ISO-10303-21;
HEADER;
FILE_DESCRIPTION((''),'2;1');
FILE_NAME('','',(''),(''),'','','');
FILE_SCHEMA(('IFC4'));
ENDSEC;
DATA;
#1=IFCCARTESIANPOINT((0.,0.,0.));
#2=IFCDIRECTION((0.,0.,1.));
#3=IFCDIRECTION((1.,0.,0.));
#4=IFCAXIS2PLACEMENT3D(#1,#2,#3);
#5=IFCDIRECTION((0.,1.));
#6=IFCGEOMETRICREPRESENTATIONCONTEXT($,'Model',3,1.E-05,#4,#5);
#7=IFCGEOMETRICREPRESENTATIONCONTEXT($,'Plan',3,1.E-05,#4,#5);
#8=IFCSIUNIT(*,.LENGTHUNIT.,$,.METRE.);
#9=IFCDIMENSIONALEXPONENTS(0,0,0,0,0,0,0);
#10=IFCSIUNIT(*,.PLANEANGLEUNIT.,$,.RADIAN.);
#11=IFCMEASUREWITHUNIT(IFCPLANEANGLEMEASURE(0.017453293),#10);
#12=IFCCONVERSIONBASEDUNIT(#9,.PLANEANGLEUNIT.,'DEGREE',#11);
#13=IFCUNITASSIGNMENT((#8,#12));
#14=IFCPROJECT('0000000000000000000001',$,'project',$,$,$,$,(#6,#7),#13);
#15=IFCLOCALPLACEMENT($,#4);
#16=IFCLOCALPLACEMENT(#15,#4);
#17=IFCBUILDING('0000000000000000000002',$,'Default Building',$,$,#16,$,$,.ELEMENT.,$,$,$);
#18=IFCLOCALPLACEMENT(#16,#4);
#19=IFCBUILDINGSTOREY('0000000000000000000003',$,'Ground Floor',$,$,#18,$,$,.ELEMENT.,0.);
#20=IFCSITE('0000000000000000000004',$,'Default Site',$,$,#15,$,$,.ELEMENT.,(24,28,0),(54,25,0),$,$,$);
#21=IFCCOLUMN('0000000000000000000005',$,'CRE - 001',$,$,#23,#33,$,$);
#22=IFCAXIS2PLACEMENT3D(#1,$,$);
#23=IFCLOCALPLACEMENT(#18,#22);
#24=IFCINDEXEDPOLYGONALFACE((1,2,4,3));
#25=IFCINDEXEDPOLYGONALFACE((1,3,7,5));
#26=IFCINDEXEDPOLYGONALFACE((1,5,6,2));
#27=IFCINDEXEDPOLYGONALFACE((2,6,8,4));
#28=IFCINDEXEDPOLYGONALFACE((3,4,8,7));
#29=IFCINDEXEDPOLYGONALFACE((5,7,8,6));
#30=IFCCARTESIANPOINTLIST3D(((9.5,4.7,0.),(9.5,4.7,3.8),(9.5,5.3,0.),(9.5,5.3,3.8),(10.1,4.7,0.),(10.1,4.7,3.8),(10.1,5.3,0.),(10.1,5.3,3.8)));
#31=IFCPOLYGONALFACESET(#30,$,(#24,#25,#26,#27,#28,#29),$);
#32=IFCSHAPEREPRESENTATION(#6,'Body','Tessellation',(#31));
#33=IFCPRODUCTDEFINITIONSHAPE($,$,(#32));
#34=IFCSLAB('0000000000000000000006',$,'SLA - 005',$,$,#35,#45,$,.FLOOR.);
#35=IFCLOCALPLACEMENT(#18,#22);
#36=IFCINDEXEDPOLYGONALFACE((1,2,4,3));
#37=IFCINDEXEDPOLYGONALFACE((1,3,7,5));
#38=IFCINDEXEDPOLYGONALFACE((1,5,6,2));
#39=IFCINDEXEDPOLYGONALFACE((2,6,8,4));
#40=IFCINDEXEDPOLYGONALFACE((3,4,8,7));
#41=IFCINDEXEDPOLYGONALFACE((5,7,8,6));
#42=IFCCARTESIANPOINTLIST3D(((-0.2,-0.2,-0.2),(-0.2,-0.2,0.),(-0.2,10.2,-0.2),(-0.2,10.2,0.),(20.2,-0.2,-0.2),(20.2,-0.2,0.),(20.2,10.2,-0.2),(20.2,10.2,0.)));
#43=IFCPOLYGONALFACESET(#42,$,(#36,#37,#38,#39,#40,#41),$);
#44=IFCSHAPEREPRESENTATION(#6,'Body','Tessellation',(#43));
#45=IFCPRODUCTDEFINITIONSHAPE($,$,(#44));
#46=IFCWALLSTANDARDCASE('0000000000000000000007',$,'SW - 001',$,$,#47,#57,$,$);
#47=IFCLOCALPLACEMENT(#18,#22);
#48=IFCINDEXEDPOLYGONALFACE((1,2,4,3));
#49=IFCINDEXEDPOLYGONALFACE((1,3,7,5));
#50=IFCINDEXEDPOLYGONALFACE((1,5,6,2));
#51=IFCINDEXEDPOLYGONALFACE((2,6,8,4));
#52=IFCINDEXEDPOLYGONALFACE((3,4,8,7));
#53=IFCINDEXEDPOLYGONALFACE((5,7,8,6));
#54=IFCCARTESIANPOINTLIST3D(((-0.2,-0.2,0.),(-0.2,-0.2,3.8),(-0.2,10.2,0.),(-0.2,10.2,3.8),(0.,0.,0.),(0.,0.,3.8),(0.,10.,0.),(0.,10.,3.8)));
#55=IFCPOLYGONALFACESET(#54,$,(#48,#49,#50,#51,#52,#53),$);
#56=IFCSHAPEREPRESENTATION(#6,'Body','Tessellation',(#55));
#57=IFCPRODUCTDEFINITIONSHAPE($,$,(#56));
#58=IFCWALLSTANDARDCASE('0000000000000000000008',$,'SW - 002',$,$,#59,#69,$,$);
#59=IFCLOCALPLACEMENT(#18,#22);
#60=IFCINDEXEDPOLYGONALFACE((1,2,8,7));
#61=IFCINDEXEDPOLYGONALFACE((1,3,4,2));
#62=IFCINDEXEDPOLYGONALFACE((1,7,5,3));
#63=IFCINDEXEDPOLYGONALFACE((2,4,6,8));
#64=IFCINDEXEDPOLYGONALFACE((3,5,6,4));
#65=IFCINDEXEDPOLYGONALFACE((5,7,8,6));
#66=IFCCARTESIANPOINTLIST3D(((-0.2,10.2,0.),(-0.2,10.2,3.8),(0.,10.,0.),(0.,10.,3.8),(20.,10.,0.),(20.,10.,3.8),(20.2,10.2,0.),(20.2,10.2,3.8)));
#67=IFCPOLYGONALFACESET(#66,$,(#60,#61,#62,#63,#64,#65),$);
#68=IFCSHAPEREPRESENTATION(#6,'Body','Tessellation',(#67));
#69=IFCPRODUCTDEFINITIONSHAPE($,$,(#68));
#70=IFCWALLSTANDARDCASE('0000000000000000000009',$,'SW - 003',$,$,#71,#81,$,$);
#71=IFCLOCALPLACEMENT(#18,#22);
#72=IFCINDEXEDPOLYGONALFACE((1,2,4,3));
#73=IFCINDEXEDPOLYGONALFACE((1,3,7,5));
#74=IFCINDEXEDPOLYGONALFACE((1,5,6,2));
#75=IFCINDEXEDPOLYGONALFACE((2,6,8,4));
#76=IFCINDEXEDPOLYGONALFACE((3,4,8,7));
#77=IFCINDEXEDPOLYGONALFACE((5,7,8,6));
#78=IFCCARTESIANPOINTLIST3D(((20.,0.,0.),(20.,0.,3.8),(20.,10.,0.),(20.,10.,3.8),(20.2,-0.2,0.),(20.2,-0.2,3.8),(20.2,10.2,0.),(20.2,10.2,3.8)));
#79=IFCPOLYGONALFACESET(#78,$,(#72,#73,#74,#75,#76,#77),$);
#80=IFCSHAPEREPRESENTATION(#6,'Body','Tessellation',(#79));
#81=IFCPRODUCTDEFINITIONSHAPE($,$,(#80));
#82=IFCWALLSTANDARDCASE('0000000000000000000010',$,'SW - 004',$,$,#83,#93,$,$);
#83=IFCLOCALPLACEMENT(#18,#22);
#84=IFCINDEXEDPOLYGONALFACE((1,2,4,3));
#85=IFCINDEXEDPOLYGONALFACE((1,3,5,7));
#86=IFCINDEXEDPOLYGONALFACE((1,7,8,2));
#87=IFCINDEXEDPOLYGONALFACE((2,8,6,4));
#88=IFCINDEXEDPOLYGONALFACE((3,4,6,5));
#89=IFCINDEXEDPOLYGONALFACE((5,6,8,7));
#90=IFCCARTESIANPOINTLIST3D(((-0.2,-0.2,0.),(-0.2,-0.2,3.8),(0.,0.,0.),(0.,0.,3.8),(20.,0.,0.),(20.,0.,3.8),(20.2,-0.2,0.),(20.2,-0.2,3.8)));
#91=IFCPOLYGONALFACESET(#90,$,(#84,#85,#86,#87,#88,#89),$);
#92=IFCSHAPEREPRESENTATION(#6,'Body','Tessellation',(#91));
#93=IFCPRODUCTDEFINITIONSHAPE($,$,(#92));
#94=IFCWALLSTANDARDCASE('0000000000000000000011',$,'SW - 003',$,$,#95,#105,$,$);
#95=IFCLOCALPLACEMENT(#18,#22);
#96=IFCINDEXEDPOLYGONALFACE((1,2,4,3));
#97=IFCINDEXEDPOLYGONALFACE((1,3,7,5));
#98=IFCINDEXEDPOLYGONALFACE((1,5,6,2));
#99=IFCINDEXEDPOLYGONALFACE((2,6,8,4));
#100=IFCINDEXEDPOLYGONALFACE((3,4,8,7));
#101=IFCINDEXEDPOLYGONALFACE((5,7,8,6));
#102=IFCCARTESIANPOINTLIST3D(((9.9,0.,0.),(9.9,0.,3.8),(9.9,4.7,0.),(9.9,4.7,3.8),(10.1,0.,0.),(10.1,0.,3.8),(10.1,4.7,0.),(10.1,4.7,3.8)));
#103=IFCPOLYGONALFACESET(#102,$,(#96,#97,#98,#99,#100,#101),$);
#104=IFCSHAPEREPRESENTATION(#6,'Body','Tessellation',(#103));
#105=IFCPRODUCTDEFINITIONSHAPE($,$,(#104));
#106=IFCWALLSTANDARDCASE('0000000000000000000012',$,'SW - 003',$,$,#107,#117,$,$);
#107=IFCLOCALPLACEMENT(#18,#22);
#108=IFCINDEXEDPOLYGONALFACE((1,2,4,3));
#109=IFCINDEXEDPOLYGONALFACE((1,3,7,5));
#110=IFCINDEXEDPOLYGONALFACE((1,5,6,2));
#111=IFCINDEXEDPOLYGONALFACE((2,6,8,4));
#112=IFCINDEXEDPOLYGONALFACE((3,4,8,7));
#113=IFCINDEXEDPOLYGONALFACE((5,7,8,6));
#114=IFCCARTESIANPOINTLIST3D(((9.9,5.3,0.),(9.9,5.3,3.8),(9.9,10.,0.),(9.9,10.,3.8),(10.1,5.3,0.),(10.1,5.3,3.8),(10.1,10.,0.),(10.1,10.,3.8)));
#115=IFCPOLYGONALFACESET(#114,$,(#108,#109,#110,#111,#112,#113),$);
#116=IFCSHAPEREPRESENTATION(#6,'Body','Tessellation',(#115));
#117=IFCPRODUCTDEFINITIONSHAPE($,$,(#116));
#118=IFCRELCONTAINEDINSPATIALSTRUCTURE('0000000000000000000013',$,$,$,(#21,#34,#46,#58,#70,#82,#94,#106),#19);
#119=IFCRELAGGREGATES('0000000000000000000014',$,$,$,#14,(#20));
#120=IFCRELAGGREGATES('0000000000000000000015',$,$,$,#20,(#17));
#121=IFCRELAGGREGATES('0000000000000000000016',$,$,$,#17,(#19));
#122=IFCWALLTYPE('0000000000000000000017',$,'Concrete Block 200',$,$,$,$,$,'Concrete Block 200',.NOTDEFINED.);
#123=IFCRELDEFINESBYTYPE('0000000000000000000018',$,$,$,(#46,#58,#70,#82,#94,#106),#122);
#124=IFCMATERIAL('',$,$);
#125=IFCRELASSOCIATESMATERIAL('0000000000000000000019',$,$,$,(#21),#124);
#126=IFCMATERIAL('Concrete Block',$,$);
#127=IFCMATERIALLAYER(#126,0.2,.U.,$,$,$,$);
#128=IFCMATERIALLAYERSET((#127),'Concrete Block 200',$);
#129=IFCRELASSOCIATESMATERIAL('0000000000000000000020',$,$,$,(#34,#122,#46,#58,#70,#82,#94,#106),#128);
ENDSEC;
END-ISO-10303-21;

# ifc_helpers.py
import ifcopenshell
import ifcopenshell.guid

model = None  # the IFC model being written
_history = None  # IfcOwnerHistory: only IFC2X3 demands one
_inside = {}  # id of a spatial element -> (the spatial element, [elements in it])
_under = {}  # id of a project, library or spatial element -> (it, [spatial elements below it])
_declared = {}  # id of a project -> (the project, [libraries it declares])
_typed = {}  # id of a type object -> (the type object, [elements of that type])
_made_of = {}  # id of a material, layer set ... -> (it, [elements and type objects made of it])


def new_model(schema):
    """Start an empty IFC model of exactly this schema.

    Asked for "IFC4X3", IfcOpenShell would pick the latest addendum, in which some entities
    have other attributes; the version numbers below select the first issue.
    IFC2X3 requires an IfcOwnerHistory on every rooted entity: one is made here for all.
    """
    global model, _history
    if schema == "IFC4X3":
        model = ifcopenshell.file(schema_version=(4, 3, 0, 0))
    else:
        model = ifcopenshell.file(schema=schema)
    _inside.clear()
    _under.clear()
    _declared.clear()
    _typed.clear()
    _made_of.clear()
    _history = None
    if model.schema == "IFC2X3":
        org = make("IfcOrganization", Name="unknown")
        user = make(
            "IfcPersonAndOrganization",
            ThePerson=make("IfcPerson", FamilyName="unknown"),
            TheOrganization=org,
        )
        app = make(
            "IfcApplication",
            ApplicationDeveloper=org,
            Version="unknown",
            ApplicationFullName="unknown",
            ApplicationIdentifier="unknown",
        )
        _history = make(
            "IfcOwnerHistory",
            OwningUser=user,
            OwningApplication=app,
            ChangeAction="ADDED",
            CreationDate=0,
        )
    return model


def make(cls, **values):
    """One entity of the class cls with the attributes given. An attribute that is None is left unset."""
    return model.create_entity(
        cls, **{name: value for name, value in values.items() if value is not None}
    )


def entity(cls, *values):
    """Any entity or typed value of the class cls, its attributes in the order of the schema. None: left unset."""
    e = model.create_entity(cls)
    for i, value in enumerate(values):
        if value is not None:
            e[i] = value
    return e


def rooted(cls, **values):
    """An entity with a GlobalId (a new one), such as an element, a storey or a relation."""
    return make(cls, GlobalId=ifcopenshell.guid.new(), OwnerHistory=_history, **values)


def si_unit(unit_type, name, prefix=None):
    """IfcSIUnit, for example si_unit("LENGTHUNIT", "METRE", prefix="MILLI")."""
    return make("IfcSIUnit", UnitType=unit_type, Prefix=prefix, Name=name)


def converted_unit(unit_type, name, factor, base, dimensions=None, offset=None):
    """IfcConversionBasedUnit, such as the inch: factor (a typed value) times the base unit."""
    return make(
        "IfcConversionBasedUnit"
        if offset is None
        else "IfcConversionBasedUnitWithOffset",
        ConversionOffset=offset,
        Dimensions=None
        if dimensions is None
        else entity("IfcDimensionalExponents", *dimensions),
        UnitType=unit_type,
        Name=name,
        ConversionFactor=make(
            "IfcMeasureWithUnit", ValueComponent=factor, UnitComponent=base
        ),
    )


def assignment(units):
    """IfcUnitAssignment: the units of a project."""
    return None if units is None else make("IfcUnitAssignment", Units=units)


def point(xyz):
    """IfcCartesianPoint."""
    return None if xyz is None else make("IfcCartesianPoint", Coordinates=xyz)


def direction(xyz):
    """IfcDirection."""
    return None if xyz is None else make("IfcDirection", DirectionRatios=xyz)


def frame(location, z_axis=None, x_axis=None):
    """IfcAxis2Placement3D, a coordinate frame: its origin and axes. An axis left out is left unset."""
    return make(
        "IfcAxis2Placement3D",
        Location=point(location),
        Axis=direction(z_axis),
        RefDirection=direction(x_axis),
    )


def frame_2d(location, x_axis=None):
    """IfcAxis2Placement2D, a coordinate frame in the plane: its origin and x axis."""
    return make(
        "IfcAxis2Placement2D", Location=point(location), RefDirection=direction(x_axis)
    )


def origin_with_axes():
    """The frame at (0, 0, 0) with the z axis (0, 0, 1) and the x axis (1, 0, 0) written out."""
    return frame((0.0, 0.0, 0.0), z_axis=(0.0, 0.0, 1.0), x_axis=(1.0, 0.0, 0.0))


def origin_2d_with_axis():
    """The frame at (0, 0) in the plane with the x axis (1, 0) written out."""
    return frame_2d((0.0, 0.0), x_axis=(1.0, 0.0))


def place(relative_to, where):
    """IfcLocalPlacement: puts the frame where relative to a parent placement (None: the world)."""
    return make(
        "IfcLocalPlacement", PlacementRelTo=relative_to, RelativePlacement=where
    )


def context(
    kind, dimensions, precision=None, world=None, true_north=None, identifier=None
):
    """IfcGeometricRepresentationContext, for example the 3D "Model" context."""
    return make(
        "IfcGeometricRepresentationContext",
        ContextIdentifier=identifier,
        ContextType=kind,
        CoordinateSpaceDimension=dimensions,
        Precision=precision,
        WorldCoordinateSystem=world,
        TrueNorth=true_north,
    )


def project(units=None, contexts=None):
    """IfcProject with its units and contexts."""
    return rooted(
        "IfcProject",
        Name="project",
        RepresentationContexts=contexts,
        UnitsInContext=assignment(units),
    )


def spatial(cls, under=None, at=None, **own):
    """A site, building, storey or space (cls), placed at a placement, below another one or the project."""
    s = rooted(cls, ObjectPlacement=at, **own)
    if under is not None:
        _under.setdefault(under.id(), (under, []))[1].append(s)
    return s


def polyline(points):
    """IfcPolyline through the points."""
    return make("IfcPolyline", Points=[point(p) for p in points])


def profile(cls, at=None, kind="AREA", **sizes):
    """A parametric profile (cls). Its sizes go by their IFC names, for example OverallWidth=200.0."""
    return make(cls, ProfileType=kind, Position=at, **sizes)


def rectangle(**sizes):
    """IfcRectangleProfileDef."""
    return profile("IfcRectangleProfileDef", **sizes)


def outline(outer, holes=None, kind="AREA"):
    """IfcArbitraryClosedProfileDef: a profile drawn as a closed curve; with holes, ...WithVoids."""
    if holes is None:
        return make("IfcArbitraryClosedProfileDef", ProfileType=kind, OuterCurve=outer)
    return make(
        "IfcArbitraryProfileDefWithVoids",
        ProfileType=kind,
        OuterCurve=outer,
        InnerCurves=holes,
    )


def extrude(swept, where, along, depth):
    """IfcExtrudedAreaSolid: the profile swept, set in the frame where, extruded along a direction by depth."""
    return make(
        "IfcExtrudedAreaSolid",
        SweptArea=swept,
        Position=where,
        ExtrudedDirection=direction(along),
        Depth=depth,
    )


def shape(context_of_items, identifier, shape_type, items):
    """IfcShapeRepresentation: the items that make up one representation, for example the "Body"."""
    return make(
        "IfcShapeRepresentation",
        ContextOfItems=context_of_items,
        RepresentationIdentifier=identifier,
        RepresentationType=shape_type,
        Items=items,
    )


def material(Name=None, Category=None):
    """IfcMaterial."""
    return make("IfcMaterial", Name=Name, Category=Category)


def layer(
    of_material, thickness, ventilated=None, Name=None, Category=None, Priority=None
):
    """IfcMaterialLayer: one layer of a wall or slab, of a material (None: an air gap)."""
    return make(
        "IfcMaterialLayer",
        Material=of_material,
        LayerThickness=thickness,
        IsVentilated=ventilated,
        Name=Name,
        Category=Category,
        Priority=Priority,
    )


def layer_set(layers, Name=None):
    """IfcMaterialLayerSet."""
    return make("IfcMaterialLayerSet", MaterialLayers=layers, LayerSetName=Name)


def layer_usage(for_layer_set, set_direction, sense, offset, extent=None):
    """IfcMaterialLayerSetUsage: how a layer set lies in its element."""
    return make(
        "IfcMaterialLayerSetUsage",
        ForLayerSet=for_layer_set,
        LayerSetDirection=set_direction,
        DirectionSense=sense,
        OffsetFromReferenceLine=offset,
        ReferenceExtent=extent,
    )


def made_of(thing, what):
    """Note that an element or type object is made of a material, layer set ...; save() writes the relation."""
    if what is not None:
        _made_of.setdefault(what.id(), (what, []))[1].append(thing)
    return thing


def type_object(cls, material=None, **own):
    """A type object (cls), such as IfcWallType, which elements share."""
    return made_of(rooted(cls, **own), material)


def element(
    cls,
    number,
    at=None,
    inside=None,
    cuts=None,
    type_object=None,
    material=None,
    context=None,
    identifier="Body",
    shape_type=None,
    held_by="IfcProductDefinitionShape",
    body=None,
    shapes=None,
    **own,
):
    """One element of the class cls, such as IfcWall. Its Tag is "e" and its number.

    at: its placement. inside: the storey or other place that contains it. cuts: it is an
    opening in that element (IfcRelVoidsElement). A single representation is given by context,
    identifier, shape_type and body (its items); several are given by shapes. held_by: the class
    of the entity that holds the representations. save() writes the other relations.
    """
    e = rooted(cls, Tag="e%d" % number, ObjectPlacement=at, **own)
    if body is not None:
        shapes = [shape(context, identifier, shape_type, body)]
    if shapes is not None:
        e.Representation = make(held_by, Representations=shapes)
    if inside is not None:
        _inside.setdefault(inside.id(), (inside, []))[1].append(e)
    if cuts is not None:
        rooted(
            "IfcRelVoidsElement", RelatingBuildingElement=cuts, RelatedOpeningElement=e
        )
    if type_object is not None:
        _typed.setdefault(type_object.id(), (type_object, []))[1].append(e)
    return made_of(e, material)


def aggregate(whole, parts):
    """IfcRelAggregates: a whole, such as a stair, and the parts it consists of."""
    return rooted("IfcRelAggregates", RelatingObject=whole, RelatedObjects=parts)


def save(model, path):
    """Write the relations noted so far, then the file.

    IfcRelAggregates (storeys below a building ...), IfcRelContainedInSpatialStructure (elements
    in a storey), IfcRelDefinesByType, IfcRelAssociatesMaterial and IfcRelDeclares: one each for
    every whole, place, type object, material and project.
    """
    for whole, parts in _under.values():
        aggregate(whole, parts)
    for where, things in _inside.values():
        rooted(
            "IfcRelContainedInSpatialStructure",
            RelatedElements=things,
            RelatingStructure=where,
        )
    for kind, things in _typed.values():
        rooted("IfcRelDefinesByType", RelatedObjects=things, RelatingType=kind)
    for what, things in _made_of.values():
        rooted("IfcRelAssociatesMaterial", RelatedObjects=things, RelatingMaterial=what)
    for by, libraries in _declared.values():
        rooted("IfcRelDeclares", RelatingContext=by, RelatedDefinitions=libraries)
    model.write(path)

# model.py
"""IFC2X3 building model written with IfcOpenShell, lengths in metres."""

from ifc_helpers import new_model, entity, si_unit, converted_unit, direction, frame, origin_with_axes, origin_2d_with_axis, place, context, project, spatial, polyline, rectangle, outline, extrude, material, layer, layer_set, layer_usage, type_object, element, save


model = new_model("IFC2X3")

# Units and contexts
model_context = context("Model", 3, precision=1e-05, world=origin_with_axes(), true_north=direction((0.0, 1.0)))
plan_context = context("Plan", 3, precision=1e-05, world=origin_with_axes(), true_north=direction((0.0, 1.0)))
ifc_project = project(units=[si_unit("LENGTHUNIT", "METRE"), converted_unit("PLANEANGLEUNIT", "DEGREE", entity("IfcPlaneAngleMeasure", 0.017453293), si_unit("PLANEANGLEUNIT", "RADIAN"), dimensions=[0, 0, 0, 0, 0, 0, 0])], contexts=[model_context, plan_context])

# Site, building, storey
site_placement = place(None, origin_with_axes())
site = spatial("IfcSite", under=ifc_project, at=site_placement, Name="Default Site", CompositionType="ELEMENT", RefLatitude=(24, 28, 0), RefLongitude=(54, 25, 0))
building_placement = place(site_placement, origin_with_axes())
building = spatial("IfcBuilding", under=site, at=building_placement, Name="Default Building", CompositionType="ELEMENT")
storey_placement = place(building_placement, origin_with_axes())
storey = spatial("IfcBuildingStorey", under=building, at=storey_placement, Name="Ground Floor", CompositionType="ELEMENT", Elevation=0.0)

# Column
ifc_material_1 = material(Name="")
column_placement = place(storey_placement, frame((9.8, 5.0, 0.0), z_axis=(0.0, 0.0, 1.0), x_axis=(1.0, 0.0, 0.0)))
element("IfcColumn", 1, at=column_placement, inside=storey, material=ifc_material_1, Name="CRE - 001", context=model_context, shape_type="SweptSolid", body=[
    extrude(rectangle(XDim=0.6, YDim=0.6, at=origin_2d_with_axis()), origin_with_axes(), (0.0, 0.0, 1.0), 3.8),
])

# Slab
ifc_material_2 = material(Name="Concrete Block")
ifc_layer = layer(ifc_material_2, 0.2, ventilated="UNKNOWN")
ifc_layer_set = layer_set([ifc_layer], Name="Concrete Block 200")
ifc_layer_usage_1 = layer_usage(ifc_layer_set, "AXIS3", "NEGATIVE", 0.2)
slab_placement = place(storey_placement, frame((-0.2, 10.2, -0.2), z_axis=(0.0, 0.0, 1.0), x_axis=(1.0, 0.0, 0.0)))
element("IfcSlab", 2, at=slab_placement, inside=storey, material=ifc_layer_usage_1, Name="SLA - 005", PredefinedType="FLOOR", context=model_context, shape_type="SweptSolid", body=[
    extrude(outline(polyline([(0.0, 0.0), (20.4, 0.0), (20.4, -10.4), (0.0, -10.4), (0.0, 0.0)])), origin_with_axes(), (0.0, 0.0, 1.0), 0.2),
])

# Walls
ifc_layer_usage_2 = layer_usage(ifc_layer_set, "AXIS2", "POSITIVE", 0.0)
wall_type = type_object("IfcWallType", Name="Concrete Block 200", ElementType="Concrete Block 200", PredefinedType="NOTDEFINED", material=ifc_layer_set)
wall_1_placement = place(storey_placement, frame((0.0, 0.0, 0.0), z_axis=(0.0, 0.0, 1.0), x_axis=(0.0, 1.0, 0.0)))
element("IfcWallStandardCase", 3, at=wall_1_placement, inside=storey, type_object=wall_type, material=ifc_layer_usage_2, Name="SW - 001", context=model_context, shape_type="SweptSolid", body=[
    extrude(outline(polyline([(0.0, 0.0), (10.0, 0.0), (10.2, 0.2), (-0.2, 0.2), (0.0, 0.0)])), origin_with_axes(), (0.0, 0.0, 1.0), 3.8),
])
ifc_layer_usage_3 = layer_usage(ifc_layer_set, "AXIS2", "POSITIVE", 0.0)
wall_2_placement = place(storey_placement, frame((0.0, 10.0, 0.0), z_axis=(0.0, 0.0, 1.0), x_axis=(1.0, 0.0, 0.0)))
element("IfcWallStandardCase", 4, at=wall_2_placement, inside=storey, type_object=wall_type, material=ifc_layer_usage_3, Name="SW - 002", context=model_context, shape_type="SweptSolid", body=[
    extrude(outline(polyline([(0.0, 0.0), (20.0, 0.0), (20.2, 0.2), (-0.2, 0.2), (0.0, 0.0)])), origin_with_axes(), (0.0, 0.0, 1.0), 3.8),
])
ifc_layer_usage_4 = layer_usage(ifc_layer_set, "AXIS2", "POSITIVE", 0.0)
wall_3_placement = place(storey_placement, frame((20.0, 10.0, 0.0), z_axis=(0.0, 0.0, 1.0), x_axis=(0.0, -1.0, 0.0)))
element("IfcWallStandardCase", 5, at=wall_3_placement, inside=storey, type_object=wall_type, material=ifc_layer_usage_4, Name="SW - 003", context=model_context, shape_type="SweptSolid", body=[
    extrude(outline(polyline([(0.0, 0.0), (10.0, 0.0), (10.2, 0.2), (-0.2, 0.2), (0.0, 0.0)])), origin_with_axes(), (0.0, 0.0, 1.0), 3.8),
])
ifc_layer_usage_5 = layer_usage(ifc_layer_set, "AXIS2", "POSITIVE", 0.0)
wall_4_placement = place(storey_placement, frame((20.0, 0.0, 0.0), z_axis=(0.0, 0.0, 1.0), x_axis=(-1.0, 0.0, 0.0)))
element("IfcWallStandardCase", 6, at=wall_4_placement, inside=storey, type_object=wall_type, material=ifc_layer_usage_5, Name="SW - 004", context=model_context, shape_type="SweptSolid", body=[
    extrude(outline(polyline([(0.0, 0.0), (20.0, 0.0), (20.2, 0.2), (-0.2, 0.2), (0.0, 0.0)])), origin_with_axes(), (0.0, 0.0, 1.0), 3.8),
])
ifc_layer_usage_6 = layer_usage(ifc_layer_set, "AXIS2", "NEGATIVE", 0.0)
wall_5_placement = place(storey_placement, frame((10.1, 4.7, 0.0), z_axis=(0.0, 0.0, 1.0), x_axis=(0.0, -1.0, 0.0)))
element("IfcWallStandardCase", 7, at=wall_5_placement, inside=storey, type_object=wall_type, material=ifc_layer_usage_6, Name="SW - 003", context=model_context, shape_type="SweptSolid", body=[
    extrude(outline(polyline([(0.0, -0.2), (4.7, -0.2), (4.7, 0.0), (0.0, 0.0), (0.0, -0.2)])), origin_with_axes(), (0.0, 0.0, 1.0), 3.8),
])
ifc_layer_usage_7 = layer_usage(ifc_layer_set, "AXIS2", "NEGATIVE", 0.0)
wall_6_placement = place(storey_placement, frame((10.1, 10.0, 0.0), z_axis=(0.0, 0.0, 1.0), x_axis=(0.0, -1.0, 0.0)))
element("IfcWallStandardCase", 8, at=wall_6_placement, inside=storey, type_object=wall_type, material=ifc_layer_usage_7, Name="SW - 003", context=model_context, shape_type="SweptSolid", body=[
    extrude(outline(polyline([(0.0, -0.2), (4.7, -0.2), (4.7, 0.0), (0.0, 0.0), (0.0, -0.2)])), origin_with_axes(), (0.0, 0.0, 1.0), 3.8),
])

save(model, "model.ifc")
